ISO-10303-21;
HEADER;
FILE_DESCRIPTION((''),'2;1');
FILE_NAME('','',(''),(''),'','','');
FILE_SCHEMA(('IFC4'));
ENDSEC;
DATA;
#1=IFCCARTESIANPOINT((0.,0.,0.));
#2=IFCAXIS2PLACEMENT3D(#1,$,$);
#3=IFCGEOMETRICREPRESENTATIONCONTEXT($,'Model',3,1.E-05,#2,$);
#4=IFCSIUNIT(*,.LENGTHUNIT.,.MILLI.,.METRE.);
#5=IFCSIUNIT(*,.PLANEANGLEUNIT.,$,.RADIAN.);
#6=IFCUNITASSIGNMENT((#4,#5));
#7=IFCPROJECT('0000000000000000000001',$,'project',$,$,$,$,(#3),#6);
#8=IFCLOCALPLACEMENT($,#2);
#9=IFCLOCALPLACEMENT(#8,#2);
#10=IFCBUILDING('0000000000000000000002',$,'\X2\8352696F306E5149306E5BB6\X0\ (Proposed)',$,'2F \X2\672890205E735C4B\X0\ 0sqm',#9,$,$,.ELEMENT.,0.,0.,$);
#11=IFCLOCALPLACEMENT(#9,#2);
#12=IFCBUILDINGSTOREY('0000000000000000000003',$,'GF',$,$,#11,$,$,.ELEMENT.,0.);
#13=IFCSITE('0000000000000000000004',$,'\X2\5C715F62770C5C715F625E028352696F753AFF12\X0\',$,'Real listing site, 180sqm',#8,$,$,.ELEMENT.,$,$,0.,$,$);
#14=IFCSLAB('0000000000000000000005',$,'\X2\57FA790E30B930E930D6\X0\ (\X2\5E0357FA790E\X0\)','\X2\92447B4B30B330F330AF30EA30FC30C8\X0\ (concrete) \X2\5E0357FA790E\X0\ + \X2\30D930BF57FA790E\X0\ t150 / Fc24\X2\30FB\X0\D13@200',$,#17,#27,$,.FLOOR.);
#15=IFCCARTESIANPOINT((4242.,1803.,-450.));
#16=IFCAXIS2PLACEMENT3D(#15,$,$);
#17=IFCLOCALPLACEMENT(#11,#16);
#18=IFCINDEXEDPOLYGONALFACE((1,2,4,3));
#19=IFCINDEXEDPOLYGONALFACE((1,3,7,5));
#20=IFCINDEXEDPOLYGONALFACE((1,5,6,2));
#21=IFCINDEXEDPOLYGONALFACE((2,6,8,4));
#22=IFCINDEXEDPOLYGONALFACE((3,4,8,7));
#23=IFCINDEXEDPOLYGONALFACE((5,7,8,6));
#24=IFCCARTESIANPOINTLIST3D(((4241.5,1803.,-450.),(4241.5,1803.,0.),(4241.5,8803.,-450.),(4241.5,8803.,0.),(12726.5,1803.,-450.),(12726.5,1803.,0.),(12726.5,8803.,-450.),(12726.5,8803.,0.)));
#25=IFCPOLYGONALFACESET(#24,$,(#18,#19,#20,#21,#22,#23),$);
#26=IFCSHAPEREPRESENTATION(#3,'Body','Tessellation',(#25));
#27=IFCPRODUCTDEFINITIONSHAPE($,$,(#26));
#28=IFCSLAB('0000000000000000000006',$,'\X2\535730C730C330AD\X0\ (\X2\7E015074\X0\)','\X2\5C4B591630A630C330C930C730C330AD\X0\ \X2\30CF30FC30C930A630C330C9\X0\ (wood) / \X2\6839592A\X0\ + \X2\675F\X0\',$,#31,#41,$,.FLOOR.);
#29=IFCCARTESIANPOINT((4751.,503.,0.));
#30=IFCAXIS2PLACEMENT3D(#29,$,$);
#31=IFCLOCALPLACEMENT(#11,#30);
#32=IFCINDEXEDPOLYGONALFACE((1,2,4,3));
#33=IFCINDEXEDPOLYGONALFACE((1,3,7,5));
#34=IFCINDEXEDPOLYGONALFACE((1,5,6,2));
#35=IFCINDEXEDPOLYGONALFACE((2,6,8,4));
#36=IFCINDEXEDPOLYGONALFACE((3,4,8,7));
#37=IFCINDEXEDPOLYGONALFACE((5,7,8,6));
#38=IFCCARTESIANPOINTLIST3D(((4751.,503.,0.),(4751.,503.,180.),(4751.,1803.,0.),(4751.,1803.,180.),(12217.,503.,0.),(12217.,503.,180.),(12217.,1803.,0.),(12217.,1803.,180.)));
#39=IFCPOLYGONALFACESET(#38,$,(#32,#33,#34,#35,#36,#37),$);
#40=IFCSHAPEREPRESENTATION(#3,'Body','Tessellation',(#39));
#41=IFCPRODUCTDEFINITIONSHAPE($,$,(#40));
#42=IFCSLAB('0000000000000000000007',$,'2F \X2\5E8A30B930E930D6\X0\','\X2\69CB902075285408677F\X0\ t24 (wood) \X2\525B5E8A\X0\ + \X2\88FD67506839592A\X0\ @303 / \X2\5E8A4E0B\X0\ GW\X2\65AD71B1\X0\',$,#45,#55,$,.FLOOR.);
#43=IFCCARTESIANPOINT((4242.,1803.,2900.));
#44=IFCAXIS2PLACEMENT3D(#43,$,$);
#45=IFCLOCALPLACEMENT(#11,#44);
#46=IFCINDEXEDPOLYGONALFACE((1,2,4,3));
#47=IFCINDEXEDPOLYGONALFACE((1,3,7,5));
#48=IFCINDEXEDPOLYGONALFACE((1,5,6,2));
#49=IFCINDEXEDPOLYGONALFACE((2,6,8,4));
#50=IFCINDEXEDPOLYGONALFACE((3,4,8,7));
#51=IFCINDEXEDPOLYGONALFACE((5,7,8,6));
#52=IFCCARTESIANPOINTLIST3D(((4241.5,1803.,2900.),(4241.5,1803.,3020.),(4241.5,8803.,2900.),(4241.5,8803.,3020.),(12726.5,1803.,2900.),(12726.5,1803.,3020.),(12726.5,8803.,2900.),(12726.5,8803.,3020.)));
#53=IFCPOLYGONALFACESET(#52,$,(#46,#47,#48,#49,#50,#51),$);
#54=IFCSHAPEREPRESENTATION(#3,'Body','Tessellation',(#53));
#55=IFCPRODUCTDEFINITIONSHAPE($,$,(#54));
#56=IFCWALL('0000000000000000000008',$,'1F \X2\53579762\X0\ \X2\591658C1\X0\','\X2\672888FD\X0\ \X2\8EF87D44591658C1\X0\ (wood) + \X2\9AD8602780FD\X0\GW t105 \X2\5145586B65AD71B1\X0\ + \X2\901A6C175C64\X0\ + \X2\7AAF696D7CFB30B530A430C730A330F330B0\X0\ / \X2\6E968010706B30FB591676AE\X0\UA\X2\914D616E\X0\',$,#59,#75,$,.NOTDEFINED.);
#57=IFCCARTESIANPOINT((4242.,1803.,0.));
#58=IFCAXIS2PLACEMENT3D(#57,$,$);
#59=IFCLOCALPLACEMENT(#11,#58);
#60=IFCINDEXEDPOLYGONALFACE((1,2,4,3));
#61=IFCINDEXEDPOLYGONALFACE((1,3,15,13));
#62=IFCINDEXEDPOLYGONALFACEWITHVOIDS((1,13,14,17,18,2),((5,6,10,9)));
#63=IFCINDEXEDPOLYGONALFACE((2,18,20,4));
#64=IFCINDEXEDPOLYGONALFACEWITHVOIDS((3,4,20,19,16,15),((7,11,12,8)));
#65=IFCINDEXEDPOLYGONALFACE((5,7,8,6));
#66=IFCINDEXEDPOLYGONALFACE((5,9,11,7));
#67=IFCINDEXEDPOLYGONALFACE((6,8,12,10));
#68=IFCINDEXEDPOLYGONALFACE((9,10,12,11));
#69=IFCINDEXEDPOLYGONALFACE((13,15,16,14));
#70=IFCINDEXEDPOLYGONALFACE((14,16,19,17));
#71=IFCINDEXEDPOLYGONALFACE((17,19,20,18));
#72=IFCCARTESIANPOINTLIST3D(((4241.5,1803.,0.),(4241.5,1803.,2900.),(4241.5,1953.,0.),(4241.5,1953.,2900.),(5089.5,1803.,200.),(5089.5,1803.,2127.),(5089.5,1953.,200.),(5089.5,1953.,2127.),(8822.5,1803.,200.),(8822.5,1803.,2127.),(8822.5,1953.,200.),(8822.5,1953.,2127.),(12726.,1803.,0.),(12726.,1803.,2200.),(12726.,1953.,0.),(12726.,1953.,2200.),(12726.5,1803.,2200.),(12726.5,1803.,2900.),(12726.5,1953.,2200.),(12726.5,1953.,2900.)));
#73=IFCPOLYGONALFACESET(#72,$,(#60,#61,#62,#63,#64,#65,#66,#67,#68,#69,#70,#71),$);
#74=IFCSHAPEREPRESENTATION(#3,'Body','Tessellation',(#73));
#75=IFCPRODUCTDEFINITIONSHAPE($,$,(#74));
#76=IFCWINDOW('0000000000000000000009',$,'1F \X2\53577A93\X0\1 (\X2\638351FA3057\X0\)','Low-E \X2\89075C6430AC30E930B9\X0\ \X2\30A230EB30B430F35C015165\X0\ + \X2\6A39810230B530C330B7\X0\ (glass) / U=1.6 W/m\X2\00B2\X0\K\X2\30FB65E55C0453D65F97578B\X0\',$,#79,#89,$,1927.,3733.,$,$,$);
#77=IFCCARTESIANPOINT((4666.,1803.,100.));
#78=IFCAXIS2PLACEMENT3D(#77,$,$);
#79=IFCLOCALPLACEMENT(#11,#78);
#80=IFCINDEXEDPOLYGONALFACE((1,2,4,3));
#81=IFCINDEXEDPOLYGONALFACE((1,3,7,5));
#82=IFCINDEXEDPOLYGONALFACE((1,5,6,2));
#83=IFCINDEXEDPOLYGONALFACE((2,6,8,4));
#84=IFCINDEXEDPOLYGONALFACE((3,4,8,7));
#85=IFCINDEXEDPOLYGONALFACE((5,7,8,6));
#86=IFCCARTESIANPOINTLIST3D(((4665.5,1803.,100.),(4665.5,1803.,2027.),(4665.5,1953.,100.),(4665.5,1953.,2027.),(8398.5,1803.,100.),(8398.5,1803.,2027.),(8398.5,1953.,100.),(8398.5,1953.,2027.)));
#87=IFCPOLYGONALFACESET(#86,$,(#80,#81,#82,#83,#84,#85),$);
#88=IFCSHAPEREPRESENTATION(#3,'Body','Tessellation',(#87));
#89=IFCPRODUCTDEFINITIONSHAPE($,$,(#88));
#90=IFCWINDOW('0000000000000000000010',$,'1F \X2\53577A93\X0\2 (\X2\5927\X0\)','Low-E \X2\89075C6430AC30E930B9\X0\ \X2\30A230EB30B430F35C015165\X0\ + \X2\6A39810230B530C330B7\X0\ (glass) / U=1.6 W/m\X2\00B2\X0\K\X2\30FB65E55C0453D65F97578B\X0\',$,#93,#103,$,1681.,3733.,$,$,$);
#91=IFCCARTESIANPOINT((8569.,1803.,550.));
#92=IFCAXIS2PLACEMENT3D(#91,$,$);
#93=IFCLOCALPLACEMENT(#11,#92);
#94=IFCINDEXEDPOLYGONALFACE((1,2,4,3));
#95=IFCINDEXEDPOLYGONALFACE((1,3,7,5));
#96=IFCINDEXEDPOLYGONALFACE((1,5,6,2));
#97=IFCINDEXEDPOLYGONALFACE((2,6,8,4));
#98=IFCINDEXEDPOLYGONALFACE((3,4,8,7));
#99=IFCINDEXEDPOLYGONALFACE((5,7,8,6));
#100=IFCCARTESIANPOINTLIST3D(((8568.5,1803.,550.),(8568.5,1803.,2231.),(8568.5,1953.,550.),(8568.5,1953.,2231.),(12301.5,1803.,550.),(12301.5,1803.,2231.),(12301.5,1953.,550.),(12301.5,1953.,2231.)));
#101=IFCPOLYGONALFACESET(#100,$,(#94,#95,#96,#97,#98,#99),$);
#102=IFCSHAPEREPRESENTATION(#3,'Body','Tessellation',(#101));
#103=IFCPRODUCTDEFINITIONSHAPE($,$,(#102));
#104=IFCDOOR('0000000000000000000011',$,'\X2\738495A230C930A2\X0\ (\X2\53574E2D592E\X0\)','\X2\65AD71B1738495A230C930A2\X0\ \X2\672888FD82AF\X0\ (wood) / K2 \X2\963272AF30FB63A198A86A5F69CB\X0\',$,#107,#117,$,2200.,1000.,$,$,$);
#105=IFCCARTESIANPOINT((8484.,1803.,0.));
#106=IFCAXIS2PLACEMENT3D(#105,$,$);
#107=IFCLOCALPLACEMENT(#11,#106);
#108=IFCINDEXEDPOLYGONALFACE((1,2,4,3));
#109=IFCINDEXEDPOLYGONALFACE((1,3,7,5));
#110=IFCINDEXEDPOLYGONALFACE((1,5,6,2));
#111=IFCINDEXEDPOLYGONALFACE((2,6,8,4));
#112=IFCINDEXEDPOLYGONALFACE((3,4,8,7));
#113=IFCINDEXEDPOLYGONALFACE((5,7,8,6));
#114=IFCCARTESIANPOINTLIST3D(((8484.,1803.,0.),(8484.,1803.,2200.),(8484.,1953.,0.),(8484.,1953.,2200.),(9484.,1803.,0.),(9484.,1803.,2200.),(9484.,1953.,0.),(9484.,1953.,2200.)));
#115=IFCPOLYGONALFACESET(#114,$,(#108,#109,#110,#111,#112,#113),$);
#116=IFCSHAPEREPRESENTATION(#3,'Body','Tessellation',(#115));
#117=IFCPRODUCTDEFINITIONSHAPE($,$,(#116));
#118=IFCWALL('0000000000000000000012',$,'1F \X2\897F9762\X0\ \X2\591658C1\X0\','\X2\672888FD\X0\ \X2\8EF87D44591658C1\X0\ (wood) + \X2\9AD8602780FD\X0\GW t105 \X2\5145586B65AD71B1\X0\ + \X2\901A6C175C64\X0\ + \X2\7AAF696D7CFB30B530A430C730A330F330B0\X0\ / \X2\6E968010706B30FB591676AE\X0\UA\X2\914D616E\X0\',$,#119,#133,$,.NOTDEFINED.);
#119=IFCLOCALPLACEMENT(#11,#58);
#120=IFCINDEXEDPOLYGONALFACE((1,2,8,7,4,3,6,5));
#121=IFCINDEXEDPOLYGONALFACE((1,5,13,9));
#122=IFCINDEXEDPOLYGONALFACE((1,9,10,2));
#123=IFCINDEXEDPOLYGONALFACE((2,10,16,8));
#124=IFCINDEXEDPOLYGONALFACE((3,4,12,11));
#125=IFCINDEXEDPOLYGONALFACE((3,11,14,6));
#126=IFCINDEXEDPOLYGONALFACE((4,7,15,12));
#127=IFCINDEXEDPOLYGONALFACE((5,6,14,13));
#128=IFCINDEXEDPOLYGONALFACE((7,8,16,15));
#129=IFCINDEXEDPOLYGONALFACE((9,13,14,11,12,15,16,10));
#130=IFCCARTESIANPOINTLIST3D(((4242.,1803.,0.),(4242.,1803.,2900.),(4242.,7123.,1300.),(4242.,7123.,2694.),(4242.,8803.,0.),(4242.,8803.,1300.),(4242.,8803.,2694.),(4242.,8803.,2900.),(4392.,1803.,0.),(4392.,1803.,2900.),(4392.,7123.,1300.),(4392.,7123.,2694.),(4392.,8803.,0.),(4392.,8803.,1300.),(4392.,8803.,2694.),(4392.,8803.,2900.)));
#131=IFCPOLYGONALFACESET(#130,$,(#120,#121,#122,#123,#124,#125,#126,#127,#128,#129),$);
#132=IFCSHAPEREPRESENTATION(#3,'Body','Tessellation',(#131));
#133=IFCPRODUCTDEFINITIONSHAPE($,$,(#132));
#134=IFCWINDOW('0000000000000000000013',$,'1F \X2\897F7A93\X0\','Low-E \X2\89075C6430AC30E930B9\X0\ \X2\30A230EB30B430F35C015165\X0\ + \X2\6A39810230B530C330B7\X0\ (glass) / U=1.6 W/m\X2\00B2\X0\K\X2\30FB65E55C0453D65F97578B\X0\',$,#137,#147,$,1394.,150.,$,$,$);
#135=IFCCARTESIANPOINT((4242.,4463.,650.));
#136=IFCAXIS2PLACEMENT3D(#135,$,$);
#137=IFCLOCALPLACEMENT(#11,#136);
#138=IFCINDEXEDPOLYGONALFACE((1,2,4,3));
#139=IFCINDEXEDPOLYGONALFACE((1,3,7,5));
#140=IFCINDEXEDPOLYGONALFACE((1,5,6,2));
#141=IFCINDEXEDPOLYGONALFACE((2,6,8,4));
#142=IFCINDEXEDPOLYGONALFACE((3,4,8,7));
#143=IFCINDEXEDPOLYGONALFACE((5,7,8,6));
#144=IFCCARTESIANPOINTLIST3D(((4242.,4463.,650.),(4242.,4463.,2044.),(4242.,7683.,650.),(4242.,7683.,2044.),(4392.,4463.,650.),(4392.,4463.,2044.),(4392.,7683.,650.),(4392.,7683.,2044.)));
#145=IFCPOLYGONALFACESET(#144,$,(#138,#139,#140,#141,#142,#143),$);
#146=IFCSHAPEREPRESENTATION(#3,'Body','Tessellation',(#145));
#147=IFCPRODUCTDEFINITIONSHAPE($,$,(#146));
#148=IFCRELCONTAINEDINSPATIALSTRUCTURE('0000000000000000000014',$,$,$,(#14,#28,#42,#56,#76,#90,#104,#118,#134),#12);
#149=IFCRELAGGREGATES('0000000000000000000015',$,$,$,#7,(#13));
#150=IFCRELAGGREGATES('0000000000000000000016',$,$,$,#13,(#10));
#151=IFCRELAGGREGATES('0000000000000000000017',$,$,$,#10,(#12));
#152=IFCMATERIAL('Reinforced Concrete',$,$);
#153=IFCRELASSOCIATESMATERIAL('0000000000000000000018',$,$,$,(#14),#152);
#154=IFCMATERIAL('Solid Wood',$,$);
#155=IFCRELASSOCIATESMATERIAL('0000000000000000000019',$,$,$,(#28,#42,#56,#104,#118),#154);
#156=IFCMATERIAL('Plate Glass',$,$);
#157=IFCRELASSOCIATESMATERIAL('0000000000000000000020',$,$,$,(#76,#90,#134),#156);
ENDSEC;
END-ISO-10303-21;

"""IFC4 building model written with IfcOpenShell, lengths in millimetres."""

from ifc_helpers import new_model, si_unit, frame, frame_2d, origin, place, context, project, spatial, rectangle, extrude, material, element, fill, save


model = new_model("IFC4")

# Units and contexts
model_context = context("Model", 3, precision=1e-05, world=origin())
ifc_project = project(units=[si_unit("LENGTHUNIT", "METRE", prefix="MILLI"), si_unit("PLANEANGLEUNIT", "RADIAN")], contexts=[model_context])

# Site, building, storey
site_placement = place(None, origin())
site = spatial("IfcSite", under=ifc_project, at=site_placement, Name="山形県山形市荒楯町２", ObjectType="Real listing site, 180sqm", CompositionType="ELEMENT", RefElevation=0.0)
building_placement = place(site_placement, origin())
building = spatial("IfcBuilding", under=site, at=building_placement, Name="荒楯の光の家 (Proposed)", ObjectType="2F 木造平屋 0sqm", CompositionType="ELEMENT", ElevationOfRefHeight=0.0, ElevationOfTerrain=0.0)
storey_placement = place(building_placement, origin())
storey = spatial("IfcBuildingStorey", under=building, at=storey_placement, Name="GF", CompositionType="ELEMENT", Elevation=0.0)

# Slabs
ifc_material_1 = material(Name="Reinforced Concrete")
slab_1_placement = place(storey_placement, frame((4242.0, 1803.0, -450.0)))
element("IfcSlab", 1, at=slab_1_placement, inside=storey, material=ifc_material_1, Name="基礎スラブ (布基礎)", Description="鉄筋コンクリート (concrete) 布基礎 + ベタ基礎 t150 / Fc24・D13@200", PredefinedType="FLOOR", context=model_context, shape_type="SweptSolid", body=[
    extrude(rectangle(XDim=8485.0, YDim=7000.0, at=frame_2d((4242.0, 3500.0))), frame((4242.0, 1803.0, -450.0)), (0.0, 0.0, 1.0), 450.0),
])
ifc_material_2 = material(Name="Solid Wood")
slab_2_placement = place(storey_placement, frame((4751.0, 503.0, 0.0)))
element("IfcSlab", 2, at=slab_2_placement, inside=storey, material=ifc_material_2, Name="南デッキ (縁側)", Description="屋外ウッドデッキ ハードウッド (wood) / 根太 + 束", PredefinedType="FLOOR", context=model_context, shape_type="SweptSolid", body=[
    extrude(rectangle(XDim=7466.0, YDim=1300.0, at=frame_2d((3733.0, 650.0))), frame((4751.0, 503.0, 0.0)), (0.0, 0.0, 1.0), 180.0),
])
slab_3_placement = place(storey_placement, frame((4242.0, 1803.0, 2900.0)))
element("IfcSlab", 3, at=slab_3_placement, inside=storey, material=ifc_material_2, Name="2F 床スラブ", Description="構造用合板 t24 (wood) 剛床 + 製材根太 @303 / 床下 GW断熱", PredefinedType="FLOOR", context=model_context, shape_type="SweptSolid", body=[
    extrude(rectangle(XDim=8485.0, YDim=7000.0, at=frame_2d((4242.0, 3500.0))), frame((4242.0, 1803.0, 2900.0)), (0.0, 0.0, 1.0), 120.0),
])

# Wall, openings, windows, door
wall_1_placement = place(storey_placement, frame((4242.0, 1803.0, 0.0)))
wall_1 = element("IfcWall", 4, at=wall_1_placement, inside=storey, material=ifc_material_2, Name="1F 南面 外壁", Description="木製 軸組外壁 (wood) + 高性能GW t105 充填断熱 + 通気層 + 窯業系サイディング / 準耐火・外皮UA配慮", PredefinedType="NOTDEFINED", context=model_context, shape_type="SweptSolid", body=[
    extrude(rectangle(XDim=8485.0, YDim=150.0, at=frame_2d((4242.0, 75.0))), frame((4242.0, 1803.0, 0.0)), (0.0, 0.0, 1.0), 2900.0),
])
opening_1_placement = place(storey_placement, frame((4666.0, 1803.0, 100.0)))
opening_1 = element("IfcOpeningElement", 5, at=opening_1_placement, cuts=wall_1, PredefinedType="NOTDEFINED", context=model_context, shape_type="SweptSolid", body=[
    extrude(rectangle(XDim=3733.0, YDim=150.0, at=frame_2d((1866.0, 75.0))), frame((4666.0, 1803.0, 100.0)), (0.0, 0.0, 1.0), 1927.0),
])
opening_2_placement = place(storey_placement, frame((8569.0, 1803.0, 550.0)))
opening_2 = element("IfcOpeningElement", 6, at=opening_2_placement, cuts=wall_1, PredefinedType="NOTDEFINED", context=model_context, shape_type="SweptSolid", body=[
    extrude(rectangle(XDim=3733.0, YDim=150.0, at=frame_2d((1866.0, 75.0))), frame((8569.0, 1803.0, 550.0)), (0.0, 0.0, 1.0), 1681.0),
])
opening_3_placement = place(storey_placement, frame((8484.0, 1803.0, 0.0)))
opening_3 = element("IfcOpeningElement", 7, at=opening_3_placement, cuts=wall_1, PredefinedType="NOTDEFINED", context=model_context, shape_type="SweptSolid", body=[
    extrude(rectangle(XDim=1000.0, YDim=150.0, at=frame_2d((500.0, 75.0))), frame((8484.0, 1803.0, 0.0)), (0.0, 0.0, 1.0), 2200.0),
])
ifc_material_3 = material(Name="Plate Glass")
window_1_placement = place(storey_placement, frame((4666.0, 1803.0, 100.0)))
window_1 = element("IfcWindow", 8, at=window_1_placement, inside=storey, material=ifc_material_3, Name="1F 南窓1 (掃出し)", Description="Low-E 複層ガラス アルゴン封入 + 樹脂サッシ (glass) / U=1.6 W/m²K・日射取得型", OverallHeight=1927.0, OverallWidth=3733.0, context=model_context, shape_type="SweptSolid", body=[
    extrude(rectangle(XDim=3733.0, YDim=150.0, at=frame_2d((1866.0, 75.0))), frame((4666.0, 1803.0, 100.0)), (0.0, 0.0, 1.0), 1927.0),
])
fill(opening_1, window_1)
window_2_placement = place(storey_placement, frame((8569.0, 1803.0, 550.0)))
window_2 = element("IfcWindow", 9, at=window_2_placement, inside=storey, material=ifc_material_3, Name="1F 南窓2 (大)", Description="Low-E 複層ガラス アルゴン封入 + 樹脂サッシ (glass) / U=1.6 W/m²K・日射取得型", OverallHeight=1681.0, OverallWidth=3733.0, context=model_context, shape_type="SweptSolid", body=[
    extrude(rectangle(XDim=3733.0, YDim=150.0, at=frame_2d((1866.0, 75.0))), frame((8569.0, 1803.0, 550.0)), (0.0, 0.0, 1.0), 1681.0),
])
fill(opening_2, window_2)
door_placement = place(storey_placement, frame((8484.0, 1803.0, 0.0)))
door = element("IfcDoor", 10, at=door_placement, inside=storey, material=ifc_material_2, Name="玄関ドア (南中央)", Description="断熱玄関ドア 木製芯 (wood) / K2 防犯・採風機構", OverallHeight=2200.0, OverallWidth=1000.0, context=model_context, shape_type="SweptSolid", body=[
    extrude(rectangle(XDim=1000.0, YDim=150.0, at=frame_2d((500.0, 75.0))), frame((8484.0, 1803.0, 0.0)), (0.0, 0.0, 1.0), 2200.0),
])
fill(opening_3, door)

# Wall, opening, window
wall_2_placement = place(storey_placement, frame((4242.0, 1803.0, 0.0)))
wall_2 = element("IfcWall", 11, at=wall_2_placement, inside=storey, material=ifc_material_2, Name="1F 西面 外壁", Description="木製 軸組外壁 (wood) + 高性能GW t105 充填断熱 + 通気層 + 窯業系サイディング / 準耐火・外皮UA配慮", PredefinedType="NOTDEFINED", context=model_context, shape_type="SweptSolid", body=[
    extrude(rectangle(XDim=150.0, YDim=7000.0, at=frame_2d((75.0, 3500.0))), frame((4242.0, 1803.0, 0.0)), (0.0, 0.0, 1.0), 2900.0),
])
opening_4_placement = place(storey_placement, frame((4242.0, 4463.0, 650.0)))
opening_4 = element("IfcOpeningElement", 12, at=opening_4_placement, cuts=wall_2, PredefinedType="NOTDEFINED", context=model_context, shape_type="SweptSolid", body=[
    extrude(rectangle(XDim=150.0, YDim=3220.0, at=frame_2d((75.0, 1610.0))), frame((4242.0, 4463.0, 650.0)), (0.0, 0.0, 1.0), 1394.0),
])
window_3_placement = place(storey_placement, frame((4242.0, 4463.0, 650.0)))
window_3 = element("IfcWindow", 13, at=window_3_placement, inside=storey, material=ifc_material_3, Name="1F 西窓", Description="Low-E 複層ガラス アルゴン封入 + 樹脂サッシ (glass) / U=1.6 W/m²K・日射取得型", OverallHeight=1394.0, OverallWidth=150.0, context=model_context, shape_type="SweptSolid", body=[
    extrude(rectangle(XDim=150.0, YDim=3220.0, at=frame_2d((75.0, 1610.0))), frame((4242.0, 4463.0, 650.0)), (0.0, 0.0, 1.0), 1394.0),
])
fill(opening_4, window_3)

save(model, "model.ifc")
